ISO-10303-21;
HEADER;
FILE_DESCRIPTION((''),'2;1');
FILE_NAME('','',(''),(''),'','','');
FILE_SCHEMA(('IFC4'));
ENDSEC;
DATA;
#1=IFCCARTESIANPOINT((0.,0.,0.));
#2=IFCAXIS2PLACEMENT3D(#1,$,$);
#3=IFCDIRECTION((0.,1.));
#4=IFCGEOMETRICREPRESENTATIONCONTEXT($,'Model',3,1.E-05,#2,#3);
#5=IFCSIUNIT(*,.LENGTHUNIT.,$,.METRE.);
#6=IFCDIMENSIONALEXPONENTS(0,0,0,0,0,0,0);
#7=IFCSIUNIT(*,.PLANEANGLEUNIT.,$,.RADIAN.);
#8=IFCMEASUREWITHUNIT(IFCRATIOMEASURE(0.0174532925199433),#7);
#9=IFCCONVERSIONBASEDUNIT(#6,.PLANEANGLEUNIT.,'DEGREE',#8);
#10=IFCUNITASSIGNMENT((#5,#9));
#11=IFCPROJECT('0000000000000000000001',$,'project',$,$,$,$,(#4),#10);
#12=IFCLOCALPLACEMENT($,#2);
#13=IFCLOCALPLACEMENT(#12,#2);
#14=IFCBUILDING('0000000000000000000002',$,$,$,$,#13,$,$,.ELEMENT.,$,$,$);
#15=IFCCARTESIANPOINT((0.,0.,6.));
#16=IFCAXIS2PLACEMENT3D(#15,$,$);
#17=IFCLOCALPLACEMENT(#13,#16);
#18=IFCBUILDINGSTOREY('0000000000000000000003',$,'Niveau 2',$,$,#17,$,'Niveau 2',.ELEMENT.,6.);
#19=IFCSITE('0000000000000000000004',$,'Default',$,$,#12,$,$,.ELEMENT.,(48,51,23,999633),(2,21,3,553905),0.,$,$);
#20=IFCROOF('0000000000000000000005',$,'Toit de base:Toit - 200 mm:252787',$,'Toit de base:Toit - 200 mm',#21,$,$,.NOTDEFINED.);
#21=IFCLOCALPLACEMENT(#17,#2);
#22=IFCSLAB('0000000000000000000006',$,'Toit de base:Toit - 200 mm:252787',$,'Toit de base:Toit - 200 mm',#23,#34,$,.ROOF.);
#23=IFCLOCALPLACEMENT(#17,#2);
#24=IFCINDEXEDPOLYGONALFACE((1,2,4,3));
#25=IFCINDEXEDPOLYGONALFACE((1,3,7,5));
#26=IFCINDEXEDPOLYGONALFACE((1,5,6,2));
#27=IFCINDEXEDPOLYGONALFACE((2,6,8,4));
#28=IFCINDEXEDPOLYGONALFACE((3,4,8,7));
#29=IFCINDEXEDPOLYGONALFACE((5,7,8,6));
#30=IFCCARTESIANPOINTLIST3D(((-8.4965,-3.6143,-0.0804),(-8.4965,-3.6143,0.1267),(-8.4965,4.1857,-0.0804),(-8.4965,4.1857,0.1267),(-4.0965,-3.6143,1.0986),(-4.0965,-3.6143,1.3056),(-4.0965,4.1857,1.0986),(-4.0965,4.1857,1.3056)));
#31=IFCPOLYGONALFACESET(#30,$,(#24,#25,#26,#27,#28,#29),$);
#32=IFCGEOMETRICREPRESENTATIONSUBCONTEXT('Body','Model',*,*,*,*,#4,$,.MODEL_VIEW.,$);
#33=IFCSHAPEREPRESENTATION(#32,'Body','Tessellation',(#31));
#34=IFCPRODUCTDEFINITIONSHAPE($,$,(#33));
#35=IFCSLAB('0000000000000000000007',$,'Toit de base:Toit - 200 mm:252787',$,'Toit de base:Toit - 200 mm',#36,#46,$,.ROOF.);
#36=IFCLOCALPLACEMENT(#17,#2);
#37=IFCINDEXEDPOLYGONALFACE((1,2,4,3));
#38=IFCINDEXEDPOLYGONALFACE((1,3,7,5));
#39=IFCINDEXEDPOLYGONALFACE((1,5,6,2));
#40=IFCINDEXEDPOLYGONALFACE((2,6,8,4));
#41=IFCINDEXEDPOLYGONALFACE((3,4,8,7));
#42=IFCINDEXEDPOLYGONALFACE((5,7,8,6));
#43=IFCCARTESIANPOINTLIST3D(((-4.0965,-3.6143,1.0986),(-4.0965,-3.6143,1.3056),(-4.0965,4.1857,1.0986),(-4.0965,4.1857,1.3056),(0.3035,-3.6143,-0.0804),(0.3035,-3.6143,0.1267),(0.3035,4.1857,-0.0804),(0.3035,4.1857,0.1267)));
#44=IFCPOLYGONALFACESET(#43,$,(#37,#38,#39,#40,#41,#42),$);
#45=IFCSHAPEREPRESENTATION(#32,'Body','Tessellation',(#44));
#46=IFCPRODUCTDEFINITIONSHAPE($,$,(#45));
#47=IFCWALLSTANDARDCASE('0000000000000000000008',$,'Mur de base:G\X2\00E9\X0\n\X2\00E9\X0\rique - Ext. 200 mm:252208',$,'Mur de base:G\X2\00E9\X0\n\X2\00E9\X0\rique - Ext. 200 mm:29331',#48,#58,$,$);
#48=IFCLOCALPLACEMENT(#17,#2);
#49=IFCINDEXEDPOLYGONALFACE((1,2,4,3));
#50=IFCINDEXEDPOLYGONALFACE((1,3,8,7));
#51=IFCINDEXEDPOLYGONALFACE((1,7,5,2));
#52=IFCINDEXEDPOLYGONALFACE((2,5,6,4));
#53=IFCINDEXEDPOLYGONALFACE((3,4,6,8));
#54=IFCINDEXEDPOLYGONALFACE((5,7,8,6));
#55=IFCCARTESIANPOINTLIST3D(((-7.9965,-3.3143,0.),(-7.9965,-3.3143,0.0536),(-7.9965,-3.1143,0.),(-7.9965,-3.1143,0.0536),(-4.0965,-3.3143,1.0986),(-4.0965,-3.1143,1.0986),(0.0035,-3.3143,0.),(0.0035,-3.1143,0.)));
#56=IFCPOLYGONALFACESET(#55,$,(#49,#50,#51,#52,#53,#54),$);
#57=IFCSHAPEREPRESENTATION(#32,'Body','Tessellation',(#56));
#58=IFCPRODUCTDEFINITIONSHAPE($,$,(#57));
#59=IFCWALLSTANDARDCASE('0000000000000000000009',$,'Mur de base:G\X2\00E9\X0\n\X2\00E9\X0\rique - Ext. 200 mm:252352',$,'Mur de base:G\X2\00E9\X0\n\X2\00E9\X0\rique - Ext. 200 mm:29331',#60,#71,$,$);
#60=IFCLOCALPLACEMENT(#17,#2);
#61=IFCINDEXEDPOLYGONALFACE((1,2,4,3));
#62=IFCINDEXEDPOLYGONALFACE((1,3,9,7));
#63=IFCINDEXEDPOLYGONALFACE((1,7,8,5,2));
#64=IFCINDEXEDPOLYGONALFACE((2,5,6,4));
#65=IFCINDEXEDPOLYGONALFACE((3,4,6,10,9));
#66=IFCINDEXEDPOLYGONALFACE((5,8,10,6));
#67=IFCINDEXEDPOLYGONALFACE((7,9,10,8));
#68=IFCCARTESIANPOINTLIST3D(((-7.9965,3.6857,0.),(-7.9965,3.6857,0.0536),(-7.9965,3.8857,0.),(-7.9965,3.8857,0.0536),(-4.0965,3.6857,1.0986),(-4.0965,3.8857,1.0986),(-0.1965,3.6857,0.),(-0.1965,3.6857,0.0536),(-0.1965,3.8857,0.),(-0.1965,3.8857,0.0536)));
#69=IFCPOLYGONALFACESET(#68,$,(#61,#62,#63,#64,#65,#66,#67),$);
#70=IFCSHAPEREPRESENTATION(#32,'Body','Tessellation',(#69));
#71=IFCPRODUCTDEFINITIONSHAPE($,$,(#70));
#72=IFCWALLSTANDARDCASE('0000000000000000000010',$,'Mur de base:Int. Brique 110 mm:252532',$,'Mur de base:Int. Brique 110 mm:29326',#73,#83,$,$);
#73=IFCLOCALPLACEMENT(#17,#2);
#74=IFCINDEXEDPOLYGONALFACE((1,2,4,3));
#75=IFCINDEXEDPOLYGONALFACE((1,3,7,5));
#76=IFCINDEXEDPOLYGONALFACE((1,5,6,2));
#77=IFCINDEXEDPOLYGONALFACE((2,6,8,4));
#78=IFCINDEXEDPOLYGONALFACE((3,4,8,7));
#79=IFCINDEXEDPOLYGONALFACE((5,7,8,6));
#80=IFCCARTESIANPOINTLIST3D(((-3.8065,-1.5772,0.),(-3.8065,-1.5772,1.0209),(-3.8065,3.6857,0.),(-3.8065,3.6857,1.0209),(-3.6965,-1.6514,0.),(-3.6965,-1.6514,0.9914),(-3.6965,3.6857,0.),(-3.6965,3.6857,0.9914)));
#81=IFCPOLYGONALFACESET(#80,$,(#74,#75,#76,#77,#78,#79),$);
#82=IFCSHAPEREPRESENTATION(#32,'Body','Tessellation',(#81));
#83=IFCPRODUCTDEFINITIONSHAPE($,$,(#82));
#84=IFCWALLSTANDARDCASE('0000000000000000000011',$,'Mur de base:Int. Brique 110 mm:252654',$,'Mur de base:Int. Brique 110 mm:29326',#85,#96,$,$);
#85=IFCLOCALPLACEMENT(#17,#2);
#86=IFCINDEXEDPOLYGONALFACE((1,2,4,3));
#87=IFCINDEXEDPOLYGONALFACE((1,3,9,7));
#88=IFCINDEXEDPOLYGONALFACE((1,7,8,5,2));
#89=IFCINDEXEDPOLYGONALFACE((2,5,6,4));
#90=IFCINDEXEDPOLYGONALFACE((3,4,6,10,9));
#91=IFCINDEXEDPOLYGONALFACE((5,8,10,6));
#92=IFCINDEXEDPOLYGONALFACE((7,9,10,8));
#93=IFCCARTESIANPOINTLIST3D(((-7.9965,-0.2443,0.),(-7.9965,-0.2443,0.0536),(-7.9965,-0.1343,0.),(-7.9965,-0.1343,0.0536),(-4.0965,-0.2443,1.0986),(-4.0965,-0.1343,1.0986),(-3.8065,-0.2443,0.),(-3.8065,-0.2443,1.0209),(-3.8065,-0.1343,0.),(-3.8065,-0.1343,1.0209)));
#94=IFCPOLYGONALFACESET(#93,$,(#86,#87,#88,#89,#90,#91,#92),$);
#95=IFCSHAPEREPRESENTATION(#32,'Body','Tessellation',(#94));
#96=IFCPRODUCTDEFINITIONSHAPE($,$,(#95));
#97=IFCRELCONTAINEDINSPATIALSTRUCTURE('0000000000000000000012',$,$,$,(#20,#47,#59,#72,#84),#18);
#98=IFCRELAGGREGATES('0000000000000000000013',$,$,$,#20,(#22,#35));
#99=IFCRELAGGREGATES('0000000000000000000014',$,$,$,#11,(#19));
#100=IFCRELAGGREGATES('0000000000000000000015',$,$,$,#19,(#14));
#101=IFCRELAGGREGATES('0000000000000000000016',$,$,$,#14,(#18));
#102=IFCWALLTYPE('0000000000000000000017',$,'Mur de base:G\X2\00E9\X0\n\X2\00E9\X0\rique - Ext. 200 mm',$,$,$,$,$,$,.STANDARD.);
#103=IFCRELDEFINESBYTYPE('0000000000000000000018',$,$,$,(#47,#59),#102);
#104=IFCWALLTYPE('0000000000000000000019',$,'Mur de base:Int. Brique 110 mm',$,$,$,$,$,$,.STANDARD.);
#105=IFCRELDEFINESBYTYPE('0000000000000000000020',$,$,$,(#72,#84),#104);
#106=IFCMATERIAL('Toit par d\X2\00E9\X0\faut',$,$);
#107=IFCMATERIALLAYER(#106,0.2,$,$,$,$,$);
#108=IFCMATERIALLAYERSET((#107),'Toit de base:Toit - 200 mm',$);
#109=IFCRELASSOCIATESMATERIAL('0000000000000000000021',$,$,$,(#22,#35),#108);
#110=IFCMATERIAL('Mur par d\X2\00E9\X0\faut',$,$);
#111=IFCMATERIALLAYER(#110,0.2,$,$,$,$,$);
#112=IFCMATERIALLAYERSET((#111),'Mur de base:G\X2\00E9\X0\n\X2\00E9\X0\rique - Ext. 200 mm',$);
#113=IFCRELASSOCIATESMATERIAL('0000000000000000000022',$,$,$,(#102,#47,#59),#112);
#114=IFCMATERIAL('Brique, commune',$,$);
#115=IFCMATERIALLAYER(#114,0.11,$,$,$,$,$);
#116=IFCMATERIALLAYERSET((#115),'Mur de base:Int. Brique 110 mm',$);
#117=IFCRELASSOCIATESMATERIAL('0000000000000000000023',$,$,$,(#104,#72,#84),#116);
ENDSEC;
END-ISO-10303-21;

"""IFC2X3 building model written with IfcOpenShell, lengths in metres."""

from ifc_helpers import new_model, entity, si_unit, converted_unit, direction, frame, frame_2d, origin, place, context, subcontext, project, spatial, polyline, rectangle, outline, extrude, clip, halfspace, bounded_halfspace, material, layer, layer_set, layer_usage, type_object, element, aggregate, save


model = new_model("IFC2X3")

# Units and contexts
model_context = context("Model", 3, precision=1e-05, world=origin(), true_north=direction((0.0, 1.0)))
body_context = subcontext(model_context, "Body", "Model", "MODEL_VIEW")
ifc_project = project(units=[si_unit("LENGTHUNIT", "METRE"), converted_unit("PLANEANGLEUNIT", "DEGREE", entity("IfcRatioMeasure", 0.0174532925199433), si_unit("PLANEANGLEUNIT", "RADIAN"), dimensions=[0, 0, 0, 0, 0, 0, 0])], contexts=[model_context])

# Site, building, storey
site_placement = place(None, origin())
site = spatial("IfcSite", under=ifc_project, at=site_placement, Name="Default", CompositionType="ELEMENT", RefLatitude=(48, 51, 23, 999633), RefLongitude=(2, 21, 3, 553905), RefElevation=0.0)
building_placement = place(site_placement, origin())
building = spatial("IfcBuilding", under=site, at=building_placement, CompositionType="ELEMENT")
storey_placement = place(building_placement, frame((0.0, 0.0, 6.0)))
storey = spatial("IfcBuildingStorey", under=building, at=storey_placement, Name="Niveau 2", LongName="Niveau 2", CompositionType="ELEMENT", Elevation=6.0)

# Roof, slabs
roof_placement = place(storey_placement, frame((-8.4965, -3.6143, -0.0804)))
roof = element("IfcRoof", 1, at=roof_placement, inside=storey, Name="Toit de base:Toit - 200 mm:252787", ObjectType="Toit de base:Toit - 200 mm", ShapeType="NOTDEFINED")
ifc_material_1 = material(Name="Toit par défaut")
ifc_layer_1 = layer(ifc_material_1, 0.2)
ifc_layer_set_1 = layer_set([ifc_layer_1], Name="Toit de base:Toit - 200 mm")
slab_1_placement = place(roof_placement, origin())
slab_1 = element("IfcSlab", 2, at=slab_1_placement, material=ifc_layer_set_1, Name="Toit de base:Toit - 200 mm:252787", ObjectType="Toit de base:Toit - 200 mm", PredefinedType="ROOF", context=body_context, shape_type="SweptSolid", body=[
    extrude(rectangle(XDim=7.8, YDim=4.5552, at=frame_2d((0.0, 0.0), x_axis=(0.0, 1.0))), frame((2.2, 3.9, 0.5895), z_axis=(-0.258819, 0.0, 0.965926), x_axis=(0.965926, 0.0, 0.258819)), (0.258819, 0.0, 0.965926), 0.2071),
])
slab_2_placement = place(roof_placement, origin())
slab_2 = element("IfcSlab", 3, at=slab_2_placement, material=ifc_layer_set_1, Name="Toit de base:Toit - 200 mm:252787", ObjectType="Toit de base:Toit - 200 mm", PredefinedType="ROOF", context=body_context, shape_type="SweptSolid", body=[
    extrude(rectangle(XDim=4.5552, YDim=7.8, at=frame_2d((0.0, 0.0), x_axis=(1.0, 0.0))), frame((6.6, 3.9, 0.5895), z_axis=(0.258819, 0.0, 0.965926), x_axis=(0.965926, 0.0, -0.258819)), (-0.258819, 0.0, 0.965926), 0.2071),
])
aggregate(roof, [slab_1, slab_2])

# Walls
ifc_material_2 = material(Name="Mur par défaut")
ifc_layer_2 = layer(ifc_material_2, 0.2)
ifc_layer_set_2 = layer_set([ifc_layer_2], Name="Mur de base:Générique - Ext. 200 mm")
ifc_layer_usage_1 = layer_usage(ifc_layer_set_2, "AXIS2", "NEGATIVE", 0.1)
wall_type_1 = type_object("IfcWallType", Name="Mur de base:Générique - Ext. 200 mm", PredefinedType="STANDARD", material=ifc_layer_set_2)
wall_1_placement = place(storey_placement, frame((-7.9965, -3.2143, 0.0)))
element("IfcWallStandardCase", 4, at=wall_1_placement, inside=storey, type_object=wall_type_1, material=ifc_layer_usage_1, Name="Mur de base:Générique - Ext. 200 mm:252208", ObjectType="Mur de base:Générique - Ext. 200 mm:29331", context=body_context, shape_type="Clipping", body=[
    clip(clip(clip(extrude(rectangle(XDim=8.0, YDim=0.2, at=frame_2d((4.0, 0.0), x_axis=(-1.0, 0.0))), origin(), (0.0, 0.0, 1.0), 1.0986), bounded_halfspace(frame((0.0, -0.1, 0.0536), z_axis=(-0.258819, 0.0, 0.965926), x_axis=(0.0, -1.0, 0.0)), False, frame((0.0, -0.1, 0.0536)), polyline([(0.0, 0.0), (3.9, 0.0), (3.9, 0.2), (0.0, 0.2), (0.0, 0.0)]))), bounded_halfspace(frame((3.9, -0.1, 1.0986), z_axis=(0.258819, 0.0, 0.965926), x_axis=(0.0, 1.0, 0.0)), False, frame((3.9, -0.1, 1.0986)), polyline([(0.0, 0.0), (4.1, 0.0), (4.1, 0.2), (0.0, 0.2), (0.0, 0.0)]))), halfspace(frame((0.0, 0.0, -3.0)), True)),
])
ifc_layer_usage_2 = layer_usage(ifc_layer_set_2, "AXIS2", "NEGATIVE", 0.1)
wall_2_placement = place(storey_placement, frame((-0.1965, 3.7857, 0.0), z_axis=(0.0, 0.0, 1.0), x_axis=(-1.0, 0.0, 0.0)))
element("IfcWallStandardCase", 5, at=wall_2_placement, inside=storey, type_object=wall_type_1, material=ifc_layer_usage_2, Name="Mur de base:Générique - Ext. 200 mm:252352", ObjectType="Mur de base:Générique - Ext. 200 mm:29331", context=body_context, shape_type="Clipping", body=[
    clip(clip(clip(extrude(rectangle(XDim=7.8, YDim=0.2, at=frame_2d((3.9, 0.0), x_axis=(-1.0, 0.0))), origin(), (0.0, 0.0, 1.0), 1.0986), bounded_halfspace(frame((3.9, -0.1, 1.0986), z_axis=(0.258819, 0.0, 0.965926), x_axis=(0.0, 1.0, 0.0)), False, frame((3.9, -0.1, 1.0986)), polyline([(0.0, 0.0), (3.9, 0.0), (3.9, 0.2), (0.0, 0.2), (0.0, 0.0)]))), bounded_halfspace(frame((0.0, -0.1, 0.0536), z_axis=(-0.258819, 0.0, 0.965926), x_axis=(0.0, -1.0, 0.0)), False, frame((0.0, -0.1, 0.0536)), polyline([(0.0, 0.0), (3.9, 0.0), (3.9, 0.2), (0.0, 0.2), (0.0, 0.0)]))), halfspace(frame((0.0, 0.0, -3.0)), True)),
])
ifc_material_3 = material(Name="Brique, commune")
ifc_layer_3 = layer(ifc_material_3, 0.11)
ifc_layer_set_3 = layer_set([ifc_layer_3], Name="Mur de base:Int. Brique 110 mm")
wall_type_2 = type_object("IfcWallType", Name="Mur de base:Int. Brique 110 mm", PredefinedType="STANDARD", material=ifc_layer_set_3)
ifc_layer_usage_3 = layer_usage(ifc_layer_set_3, "AXIS2", "NEGATIVE", 0.055)
wall_3_placement = place(storey_placement, frame((-3.7515, -1.6514, 0.0), z_axis=(0.0, 0.0, 1.0), x_axis=(0.0, 1.0, 0.0)))
element("IfcWallStandardCase", 6, at=wall_3_placement, inside=storey, type_object=wall_type_2, material=ifc_layer_usage_3, Name="Mur de base:Int. Brique 110 mm:252532", ObjectType="Mur de base:Int. Brique 110 mm:29326", context=body_context, shape_type="Clipping", body=[
    clip(clip(extrude(outline(polyline([(0.0, -0.055), (5.3371, -0.055), (5.3371, 0.055), (1.5171, 0.055), (1.4071, 0.055), (0.0742, 0.055), (0.0, -0.055)])), origin(), (0.0, 0.0, 1.0), 1.0209), bounded_halfspace(frame((0.0, -0.055, 0.9914), z_axis=(0.0, -0.258819, 0.965926), x_axis=(1.0, 0.0, 0.0)), False, frame((0.0, -0.055, 0.9914)), polyline([(0.0, 0.0), (5.3371, 0.0), (5.3371, 0.11), (1.5171, 0.11), (1.4071, 0.11), (0.0742, 0.11), (0.0, 0.0)]))), halfspace(frame((0.0, 0.0, -3.0)), True)),
])
ifc_layer_usage_4 = layer_usage(ifc_layer_set_3, "AXIS2", "NEGATIVE", 0.055)
wall_4_placement = place(storey_placement, frame((-3.8065, -0.1893, 0.0), z_axis=(0.0, 0.0, 1.0), x_axis=(-1.0, 0.0, 0.0)))
element("IfcWallStandardCase", 7, at=wall_4_placement, inside=storey, type_object=wall_type_2, material=ifc_layer_usage_4, Name="Mur de base:Int. Brique 110 mm:252654", ObjectType="Mur de base:Int. Brique 110 mm:29326", context=body_context, shape_type="Clipping", body=[
    clip(clip(clip(extrude(rectangle(XDim=4.19, YDim=0.11, at=frame_2d((2.095, 0.0), x_axis=(-1.0, 0.0))), origin(), (0.0, 0.0, 1.0), 1.0986), bounded_halfspace(frame((4.19, -0.055, 0.0536), z_axis=(0.258819, 0.0, 0.965926), x_axis=(0.0, 1.0, 0.0)), False, frame((4.19, -0.055, 0.0536)), polyline([(0.0, 0.0), (0.0, 0.11), (-3.9, 0.11), (-3.9, 0.0), (0.0, 0.0)]))), bounded_halfspace(frame((0.0, 0.055, 1.0209), z_axis=(-0.258819, 0.0, 0.965926), x_axis=(0.0, -1.0, 0.0)), False, frame((0.0, 0.055, 1.0209)), polyline([(0.0, 0.0), (0.0, -0.11), (0.29, -0.11), (0.29, 0.0), (0.0, 0.0)]))), halfspace(frame((0.0, 0.0, -3.0)), True)),
])

save(model, "model.ifc")
